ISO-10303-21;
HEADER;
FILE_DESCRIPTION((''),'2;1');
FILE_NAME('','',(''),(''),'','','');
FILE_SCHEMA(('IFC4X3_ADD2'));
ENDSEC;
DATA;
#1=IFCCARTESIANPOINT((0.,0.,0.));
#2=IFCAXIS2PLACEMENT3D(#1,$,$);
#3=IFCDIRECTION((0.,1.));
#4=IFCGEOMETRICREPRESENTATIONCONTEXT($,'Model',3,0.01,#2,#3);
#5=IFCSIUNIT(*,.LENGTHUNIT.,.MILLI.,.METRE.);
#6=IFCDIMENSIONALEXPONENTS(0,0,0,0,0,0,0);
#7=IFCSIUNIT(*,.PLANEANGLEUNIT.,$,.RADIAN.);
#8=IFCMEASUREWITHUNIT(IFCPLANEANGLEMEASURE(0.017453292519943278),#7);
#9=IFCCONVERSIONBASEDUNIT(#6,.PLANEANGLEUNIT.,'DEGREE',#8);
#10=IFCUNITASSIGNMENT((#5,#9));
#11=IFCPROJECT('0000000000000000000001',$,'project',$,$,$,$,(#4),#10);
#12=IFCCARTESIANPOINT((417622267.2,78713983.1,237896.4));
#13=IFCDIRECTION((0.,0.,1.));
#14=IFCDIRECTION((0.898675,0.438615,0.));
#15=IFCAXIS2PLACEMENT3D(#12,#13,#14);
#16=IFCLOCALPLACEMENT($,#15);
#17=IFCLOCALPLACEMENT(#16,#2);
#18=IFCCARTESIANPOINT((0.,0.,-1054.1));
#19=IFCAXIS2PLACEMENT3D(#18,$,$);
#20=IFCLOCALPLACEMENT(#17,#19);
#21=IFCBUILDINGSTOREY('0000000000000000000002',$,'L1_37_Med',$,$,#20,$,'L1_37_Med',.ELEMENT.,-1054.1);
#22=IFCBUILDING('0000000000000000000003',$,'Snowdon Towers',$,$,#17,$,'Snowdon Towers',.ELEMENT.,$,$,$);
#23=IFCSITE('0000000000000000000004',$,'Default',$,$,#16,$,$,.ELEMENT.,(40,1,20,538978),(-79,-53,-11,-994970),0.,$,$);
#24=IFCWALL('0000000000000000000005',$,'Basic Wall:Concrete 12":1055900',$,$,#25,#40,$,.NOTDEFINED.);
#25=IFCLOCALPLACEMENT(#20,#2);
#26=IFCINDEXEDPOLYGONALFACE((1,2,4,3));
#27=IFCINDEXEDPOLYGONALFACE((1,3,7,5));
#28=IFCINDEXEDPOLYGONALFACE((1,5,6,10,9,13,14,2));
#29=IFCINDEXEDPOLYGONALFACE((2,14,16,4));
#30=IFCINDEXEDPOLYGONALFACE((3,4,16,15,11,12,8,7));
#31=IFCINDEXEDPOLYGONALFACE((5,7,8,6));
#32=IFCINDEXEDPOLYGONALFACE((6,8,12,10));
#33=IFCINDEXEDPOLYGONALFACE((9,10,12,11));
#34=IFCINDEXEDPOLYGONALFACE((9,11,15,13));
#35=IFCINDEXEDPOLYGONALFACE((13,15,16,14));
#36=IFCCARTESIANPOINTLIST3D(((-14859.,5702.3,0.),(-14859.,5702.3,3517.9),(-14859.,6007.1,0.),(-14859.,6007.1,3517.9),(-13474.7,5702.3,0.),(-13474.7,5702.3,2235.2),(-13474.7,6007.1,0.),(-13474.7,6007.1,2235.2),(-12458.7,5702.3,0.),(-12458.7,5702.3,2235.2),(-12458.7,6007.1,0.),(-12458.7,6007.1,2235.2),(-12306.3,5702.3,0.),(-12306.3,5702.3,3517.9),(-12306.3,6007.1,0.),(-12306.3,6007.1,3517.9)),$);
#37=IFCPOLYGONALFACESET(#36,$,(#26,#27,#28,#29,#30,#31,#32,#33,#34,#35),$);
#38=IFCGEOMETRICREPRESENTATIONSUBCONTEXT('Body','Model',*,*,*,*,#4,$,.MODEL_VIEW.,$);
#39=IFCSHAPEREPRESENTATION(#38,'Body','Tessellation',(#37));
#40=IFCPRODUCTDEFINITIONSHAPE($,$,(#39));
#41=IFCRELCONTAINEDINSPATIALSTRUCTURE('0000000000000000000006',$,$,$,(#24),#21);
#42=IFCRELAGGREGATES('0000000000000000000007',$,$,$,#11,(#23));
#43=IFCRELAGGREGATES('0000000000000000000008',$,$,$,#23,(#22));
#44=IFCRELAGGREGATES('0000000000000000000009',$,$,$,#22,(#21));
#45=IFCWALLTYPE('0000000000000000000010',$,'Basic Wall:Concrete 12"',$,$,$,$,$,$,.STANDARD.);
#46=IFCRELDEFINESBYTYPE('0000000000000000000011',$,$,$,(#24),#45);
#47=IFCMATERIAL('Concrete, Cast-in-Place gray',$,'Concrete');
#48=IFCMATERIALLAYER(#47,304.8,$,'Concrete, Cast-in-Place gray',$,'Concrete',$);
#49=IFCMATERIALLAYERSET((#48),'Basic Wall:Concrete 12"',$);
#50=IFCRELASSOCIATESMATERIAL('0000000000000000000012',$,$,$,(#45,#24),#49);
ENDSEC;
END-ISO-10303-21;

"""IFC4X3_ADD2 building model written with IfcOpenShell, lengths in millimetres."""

from ifc_helpers import new_model, entity, si_unit, converted_unit, direction, frame, frame_2d, origin, place, context, subcontext, project, spatial, rectangle, extrude, material, layer, layer_set, type_object, element, save


model = new_model("IFC4X3_ADD2")

# Units and contexts
model_context = context("Model", 3, precision=0.01, world=origin(), true_north=direction((0.0, 1.0)))
body_context = subcontext(model_context, "Body", "Model", "MODEL_VIEW")
ifc_project = project(units=[si_unit("LENGTHUNIT", "METRE", prefix="MILLI"), converted_unit("PLANEANGLEUNIT", "DEGREE", entity("IfcPlaneAngleMeasure", 0.017453292519943278), si_unit("PLANEANGLEUNIT", "RADIAN"), dimensions=[0, 0, 0, 0, 0, 0, 0])], contexts=[model_context])

# Site, building, storey
site_placement = place(None, frame((417622267.2, 78713983.1, 237896.4), z_axis=(0.0, 0.0, 1.0), x_axis=(0.898675, 0.438615, 0.0)))
site = spatial("IfcSite", under=ifc_project, at=site_placement, Name="Default", CompositionType="ELEMENT", RefLatitude=(40, 1, 20, 538978), RefLongitude=(-79, -53, -11, -994970), RefElevation=0.0)
building_placement = place(site_placement, origin())
building = spatial("IfcBuilding", under=site, at=building_placement, Name="Snowdon Towers", LongName="Snowdon Towers", CompositionType="ELEMENT")
storey_placement = place(building_placement, frame((0.0, 0.0, -1054.1)))
storey = spatial("IfcBuildingStorey", under=building, at=storey_placement, Name="L1_37_Med", LongName="L1_37_Med", CompositionType="ELEMENT", Elevation=-1054.1)

# Shared definitions
ifc_material_1 = material(Name="Concrete, Cast-in-Place gray", Category="Concrete")

# Wall, opening
ifc_layer = layer(ifc_material_1, 304.8, Name="Concrete, Cast-in-Place gray", Category="Concrete")
ifc_layer_set = layer_set([ifc_layer], Name="Basic Wall:Concrete 12\"")
wall_type = type_object("IfcWallType", Name="Basic Wall:Concrete 12\"", PredefinedType="STANDARD", material=ifc_layer_set)
wall_placement = place(storey_placement, frame((-12306.3, 5854.7, 0.0), z_axis=(0.0, 0.0, 1.0), x_axis=(-1.0, 0.0, 0.0)))
wall = element("IfcWall", 1, at=wall_placement, inside=storey, type_object=wall_type, material=ifc_layer_set, Name="Basic Wall:Concrete 12\":1055900", PredefinedType="NOTDEFINED", context=body_context, shape_type="SweptSolid", body=[
    extrude(rectangle(XDim=2552.7, YDim=304.8, at=frame_2d((1276.3, 0.0), x_axis=(-1.0, 0.0))), origin(), (0.0, 0.0, 1.0), 3517.9),
])
opening_placement = place(wall_placement, origin())
element("IfcOpeningElement", 2, at=opening_placement, cuts=wall, PredefinedType="OPENING", context=body_context, shape_type="SweptSolid", body=[
    extrude(rectangle(XDim=2235.2, YDim=1016.0, at=frame_2d((0.0, 0.0), x_axis=(0.0, 1.0))), frame((660.4, 152.4, 1117.6), z_axis=(0.0, -1.0, 0.0), x_axis=(1.0, 0.0, 0.0)), (0.0, 0.0, 1.0), 304.8),
])

save(model, "model.ifc")
